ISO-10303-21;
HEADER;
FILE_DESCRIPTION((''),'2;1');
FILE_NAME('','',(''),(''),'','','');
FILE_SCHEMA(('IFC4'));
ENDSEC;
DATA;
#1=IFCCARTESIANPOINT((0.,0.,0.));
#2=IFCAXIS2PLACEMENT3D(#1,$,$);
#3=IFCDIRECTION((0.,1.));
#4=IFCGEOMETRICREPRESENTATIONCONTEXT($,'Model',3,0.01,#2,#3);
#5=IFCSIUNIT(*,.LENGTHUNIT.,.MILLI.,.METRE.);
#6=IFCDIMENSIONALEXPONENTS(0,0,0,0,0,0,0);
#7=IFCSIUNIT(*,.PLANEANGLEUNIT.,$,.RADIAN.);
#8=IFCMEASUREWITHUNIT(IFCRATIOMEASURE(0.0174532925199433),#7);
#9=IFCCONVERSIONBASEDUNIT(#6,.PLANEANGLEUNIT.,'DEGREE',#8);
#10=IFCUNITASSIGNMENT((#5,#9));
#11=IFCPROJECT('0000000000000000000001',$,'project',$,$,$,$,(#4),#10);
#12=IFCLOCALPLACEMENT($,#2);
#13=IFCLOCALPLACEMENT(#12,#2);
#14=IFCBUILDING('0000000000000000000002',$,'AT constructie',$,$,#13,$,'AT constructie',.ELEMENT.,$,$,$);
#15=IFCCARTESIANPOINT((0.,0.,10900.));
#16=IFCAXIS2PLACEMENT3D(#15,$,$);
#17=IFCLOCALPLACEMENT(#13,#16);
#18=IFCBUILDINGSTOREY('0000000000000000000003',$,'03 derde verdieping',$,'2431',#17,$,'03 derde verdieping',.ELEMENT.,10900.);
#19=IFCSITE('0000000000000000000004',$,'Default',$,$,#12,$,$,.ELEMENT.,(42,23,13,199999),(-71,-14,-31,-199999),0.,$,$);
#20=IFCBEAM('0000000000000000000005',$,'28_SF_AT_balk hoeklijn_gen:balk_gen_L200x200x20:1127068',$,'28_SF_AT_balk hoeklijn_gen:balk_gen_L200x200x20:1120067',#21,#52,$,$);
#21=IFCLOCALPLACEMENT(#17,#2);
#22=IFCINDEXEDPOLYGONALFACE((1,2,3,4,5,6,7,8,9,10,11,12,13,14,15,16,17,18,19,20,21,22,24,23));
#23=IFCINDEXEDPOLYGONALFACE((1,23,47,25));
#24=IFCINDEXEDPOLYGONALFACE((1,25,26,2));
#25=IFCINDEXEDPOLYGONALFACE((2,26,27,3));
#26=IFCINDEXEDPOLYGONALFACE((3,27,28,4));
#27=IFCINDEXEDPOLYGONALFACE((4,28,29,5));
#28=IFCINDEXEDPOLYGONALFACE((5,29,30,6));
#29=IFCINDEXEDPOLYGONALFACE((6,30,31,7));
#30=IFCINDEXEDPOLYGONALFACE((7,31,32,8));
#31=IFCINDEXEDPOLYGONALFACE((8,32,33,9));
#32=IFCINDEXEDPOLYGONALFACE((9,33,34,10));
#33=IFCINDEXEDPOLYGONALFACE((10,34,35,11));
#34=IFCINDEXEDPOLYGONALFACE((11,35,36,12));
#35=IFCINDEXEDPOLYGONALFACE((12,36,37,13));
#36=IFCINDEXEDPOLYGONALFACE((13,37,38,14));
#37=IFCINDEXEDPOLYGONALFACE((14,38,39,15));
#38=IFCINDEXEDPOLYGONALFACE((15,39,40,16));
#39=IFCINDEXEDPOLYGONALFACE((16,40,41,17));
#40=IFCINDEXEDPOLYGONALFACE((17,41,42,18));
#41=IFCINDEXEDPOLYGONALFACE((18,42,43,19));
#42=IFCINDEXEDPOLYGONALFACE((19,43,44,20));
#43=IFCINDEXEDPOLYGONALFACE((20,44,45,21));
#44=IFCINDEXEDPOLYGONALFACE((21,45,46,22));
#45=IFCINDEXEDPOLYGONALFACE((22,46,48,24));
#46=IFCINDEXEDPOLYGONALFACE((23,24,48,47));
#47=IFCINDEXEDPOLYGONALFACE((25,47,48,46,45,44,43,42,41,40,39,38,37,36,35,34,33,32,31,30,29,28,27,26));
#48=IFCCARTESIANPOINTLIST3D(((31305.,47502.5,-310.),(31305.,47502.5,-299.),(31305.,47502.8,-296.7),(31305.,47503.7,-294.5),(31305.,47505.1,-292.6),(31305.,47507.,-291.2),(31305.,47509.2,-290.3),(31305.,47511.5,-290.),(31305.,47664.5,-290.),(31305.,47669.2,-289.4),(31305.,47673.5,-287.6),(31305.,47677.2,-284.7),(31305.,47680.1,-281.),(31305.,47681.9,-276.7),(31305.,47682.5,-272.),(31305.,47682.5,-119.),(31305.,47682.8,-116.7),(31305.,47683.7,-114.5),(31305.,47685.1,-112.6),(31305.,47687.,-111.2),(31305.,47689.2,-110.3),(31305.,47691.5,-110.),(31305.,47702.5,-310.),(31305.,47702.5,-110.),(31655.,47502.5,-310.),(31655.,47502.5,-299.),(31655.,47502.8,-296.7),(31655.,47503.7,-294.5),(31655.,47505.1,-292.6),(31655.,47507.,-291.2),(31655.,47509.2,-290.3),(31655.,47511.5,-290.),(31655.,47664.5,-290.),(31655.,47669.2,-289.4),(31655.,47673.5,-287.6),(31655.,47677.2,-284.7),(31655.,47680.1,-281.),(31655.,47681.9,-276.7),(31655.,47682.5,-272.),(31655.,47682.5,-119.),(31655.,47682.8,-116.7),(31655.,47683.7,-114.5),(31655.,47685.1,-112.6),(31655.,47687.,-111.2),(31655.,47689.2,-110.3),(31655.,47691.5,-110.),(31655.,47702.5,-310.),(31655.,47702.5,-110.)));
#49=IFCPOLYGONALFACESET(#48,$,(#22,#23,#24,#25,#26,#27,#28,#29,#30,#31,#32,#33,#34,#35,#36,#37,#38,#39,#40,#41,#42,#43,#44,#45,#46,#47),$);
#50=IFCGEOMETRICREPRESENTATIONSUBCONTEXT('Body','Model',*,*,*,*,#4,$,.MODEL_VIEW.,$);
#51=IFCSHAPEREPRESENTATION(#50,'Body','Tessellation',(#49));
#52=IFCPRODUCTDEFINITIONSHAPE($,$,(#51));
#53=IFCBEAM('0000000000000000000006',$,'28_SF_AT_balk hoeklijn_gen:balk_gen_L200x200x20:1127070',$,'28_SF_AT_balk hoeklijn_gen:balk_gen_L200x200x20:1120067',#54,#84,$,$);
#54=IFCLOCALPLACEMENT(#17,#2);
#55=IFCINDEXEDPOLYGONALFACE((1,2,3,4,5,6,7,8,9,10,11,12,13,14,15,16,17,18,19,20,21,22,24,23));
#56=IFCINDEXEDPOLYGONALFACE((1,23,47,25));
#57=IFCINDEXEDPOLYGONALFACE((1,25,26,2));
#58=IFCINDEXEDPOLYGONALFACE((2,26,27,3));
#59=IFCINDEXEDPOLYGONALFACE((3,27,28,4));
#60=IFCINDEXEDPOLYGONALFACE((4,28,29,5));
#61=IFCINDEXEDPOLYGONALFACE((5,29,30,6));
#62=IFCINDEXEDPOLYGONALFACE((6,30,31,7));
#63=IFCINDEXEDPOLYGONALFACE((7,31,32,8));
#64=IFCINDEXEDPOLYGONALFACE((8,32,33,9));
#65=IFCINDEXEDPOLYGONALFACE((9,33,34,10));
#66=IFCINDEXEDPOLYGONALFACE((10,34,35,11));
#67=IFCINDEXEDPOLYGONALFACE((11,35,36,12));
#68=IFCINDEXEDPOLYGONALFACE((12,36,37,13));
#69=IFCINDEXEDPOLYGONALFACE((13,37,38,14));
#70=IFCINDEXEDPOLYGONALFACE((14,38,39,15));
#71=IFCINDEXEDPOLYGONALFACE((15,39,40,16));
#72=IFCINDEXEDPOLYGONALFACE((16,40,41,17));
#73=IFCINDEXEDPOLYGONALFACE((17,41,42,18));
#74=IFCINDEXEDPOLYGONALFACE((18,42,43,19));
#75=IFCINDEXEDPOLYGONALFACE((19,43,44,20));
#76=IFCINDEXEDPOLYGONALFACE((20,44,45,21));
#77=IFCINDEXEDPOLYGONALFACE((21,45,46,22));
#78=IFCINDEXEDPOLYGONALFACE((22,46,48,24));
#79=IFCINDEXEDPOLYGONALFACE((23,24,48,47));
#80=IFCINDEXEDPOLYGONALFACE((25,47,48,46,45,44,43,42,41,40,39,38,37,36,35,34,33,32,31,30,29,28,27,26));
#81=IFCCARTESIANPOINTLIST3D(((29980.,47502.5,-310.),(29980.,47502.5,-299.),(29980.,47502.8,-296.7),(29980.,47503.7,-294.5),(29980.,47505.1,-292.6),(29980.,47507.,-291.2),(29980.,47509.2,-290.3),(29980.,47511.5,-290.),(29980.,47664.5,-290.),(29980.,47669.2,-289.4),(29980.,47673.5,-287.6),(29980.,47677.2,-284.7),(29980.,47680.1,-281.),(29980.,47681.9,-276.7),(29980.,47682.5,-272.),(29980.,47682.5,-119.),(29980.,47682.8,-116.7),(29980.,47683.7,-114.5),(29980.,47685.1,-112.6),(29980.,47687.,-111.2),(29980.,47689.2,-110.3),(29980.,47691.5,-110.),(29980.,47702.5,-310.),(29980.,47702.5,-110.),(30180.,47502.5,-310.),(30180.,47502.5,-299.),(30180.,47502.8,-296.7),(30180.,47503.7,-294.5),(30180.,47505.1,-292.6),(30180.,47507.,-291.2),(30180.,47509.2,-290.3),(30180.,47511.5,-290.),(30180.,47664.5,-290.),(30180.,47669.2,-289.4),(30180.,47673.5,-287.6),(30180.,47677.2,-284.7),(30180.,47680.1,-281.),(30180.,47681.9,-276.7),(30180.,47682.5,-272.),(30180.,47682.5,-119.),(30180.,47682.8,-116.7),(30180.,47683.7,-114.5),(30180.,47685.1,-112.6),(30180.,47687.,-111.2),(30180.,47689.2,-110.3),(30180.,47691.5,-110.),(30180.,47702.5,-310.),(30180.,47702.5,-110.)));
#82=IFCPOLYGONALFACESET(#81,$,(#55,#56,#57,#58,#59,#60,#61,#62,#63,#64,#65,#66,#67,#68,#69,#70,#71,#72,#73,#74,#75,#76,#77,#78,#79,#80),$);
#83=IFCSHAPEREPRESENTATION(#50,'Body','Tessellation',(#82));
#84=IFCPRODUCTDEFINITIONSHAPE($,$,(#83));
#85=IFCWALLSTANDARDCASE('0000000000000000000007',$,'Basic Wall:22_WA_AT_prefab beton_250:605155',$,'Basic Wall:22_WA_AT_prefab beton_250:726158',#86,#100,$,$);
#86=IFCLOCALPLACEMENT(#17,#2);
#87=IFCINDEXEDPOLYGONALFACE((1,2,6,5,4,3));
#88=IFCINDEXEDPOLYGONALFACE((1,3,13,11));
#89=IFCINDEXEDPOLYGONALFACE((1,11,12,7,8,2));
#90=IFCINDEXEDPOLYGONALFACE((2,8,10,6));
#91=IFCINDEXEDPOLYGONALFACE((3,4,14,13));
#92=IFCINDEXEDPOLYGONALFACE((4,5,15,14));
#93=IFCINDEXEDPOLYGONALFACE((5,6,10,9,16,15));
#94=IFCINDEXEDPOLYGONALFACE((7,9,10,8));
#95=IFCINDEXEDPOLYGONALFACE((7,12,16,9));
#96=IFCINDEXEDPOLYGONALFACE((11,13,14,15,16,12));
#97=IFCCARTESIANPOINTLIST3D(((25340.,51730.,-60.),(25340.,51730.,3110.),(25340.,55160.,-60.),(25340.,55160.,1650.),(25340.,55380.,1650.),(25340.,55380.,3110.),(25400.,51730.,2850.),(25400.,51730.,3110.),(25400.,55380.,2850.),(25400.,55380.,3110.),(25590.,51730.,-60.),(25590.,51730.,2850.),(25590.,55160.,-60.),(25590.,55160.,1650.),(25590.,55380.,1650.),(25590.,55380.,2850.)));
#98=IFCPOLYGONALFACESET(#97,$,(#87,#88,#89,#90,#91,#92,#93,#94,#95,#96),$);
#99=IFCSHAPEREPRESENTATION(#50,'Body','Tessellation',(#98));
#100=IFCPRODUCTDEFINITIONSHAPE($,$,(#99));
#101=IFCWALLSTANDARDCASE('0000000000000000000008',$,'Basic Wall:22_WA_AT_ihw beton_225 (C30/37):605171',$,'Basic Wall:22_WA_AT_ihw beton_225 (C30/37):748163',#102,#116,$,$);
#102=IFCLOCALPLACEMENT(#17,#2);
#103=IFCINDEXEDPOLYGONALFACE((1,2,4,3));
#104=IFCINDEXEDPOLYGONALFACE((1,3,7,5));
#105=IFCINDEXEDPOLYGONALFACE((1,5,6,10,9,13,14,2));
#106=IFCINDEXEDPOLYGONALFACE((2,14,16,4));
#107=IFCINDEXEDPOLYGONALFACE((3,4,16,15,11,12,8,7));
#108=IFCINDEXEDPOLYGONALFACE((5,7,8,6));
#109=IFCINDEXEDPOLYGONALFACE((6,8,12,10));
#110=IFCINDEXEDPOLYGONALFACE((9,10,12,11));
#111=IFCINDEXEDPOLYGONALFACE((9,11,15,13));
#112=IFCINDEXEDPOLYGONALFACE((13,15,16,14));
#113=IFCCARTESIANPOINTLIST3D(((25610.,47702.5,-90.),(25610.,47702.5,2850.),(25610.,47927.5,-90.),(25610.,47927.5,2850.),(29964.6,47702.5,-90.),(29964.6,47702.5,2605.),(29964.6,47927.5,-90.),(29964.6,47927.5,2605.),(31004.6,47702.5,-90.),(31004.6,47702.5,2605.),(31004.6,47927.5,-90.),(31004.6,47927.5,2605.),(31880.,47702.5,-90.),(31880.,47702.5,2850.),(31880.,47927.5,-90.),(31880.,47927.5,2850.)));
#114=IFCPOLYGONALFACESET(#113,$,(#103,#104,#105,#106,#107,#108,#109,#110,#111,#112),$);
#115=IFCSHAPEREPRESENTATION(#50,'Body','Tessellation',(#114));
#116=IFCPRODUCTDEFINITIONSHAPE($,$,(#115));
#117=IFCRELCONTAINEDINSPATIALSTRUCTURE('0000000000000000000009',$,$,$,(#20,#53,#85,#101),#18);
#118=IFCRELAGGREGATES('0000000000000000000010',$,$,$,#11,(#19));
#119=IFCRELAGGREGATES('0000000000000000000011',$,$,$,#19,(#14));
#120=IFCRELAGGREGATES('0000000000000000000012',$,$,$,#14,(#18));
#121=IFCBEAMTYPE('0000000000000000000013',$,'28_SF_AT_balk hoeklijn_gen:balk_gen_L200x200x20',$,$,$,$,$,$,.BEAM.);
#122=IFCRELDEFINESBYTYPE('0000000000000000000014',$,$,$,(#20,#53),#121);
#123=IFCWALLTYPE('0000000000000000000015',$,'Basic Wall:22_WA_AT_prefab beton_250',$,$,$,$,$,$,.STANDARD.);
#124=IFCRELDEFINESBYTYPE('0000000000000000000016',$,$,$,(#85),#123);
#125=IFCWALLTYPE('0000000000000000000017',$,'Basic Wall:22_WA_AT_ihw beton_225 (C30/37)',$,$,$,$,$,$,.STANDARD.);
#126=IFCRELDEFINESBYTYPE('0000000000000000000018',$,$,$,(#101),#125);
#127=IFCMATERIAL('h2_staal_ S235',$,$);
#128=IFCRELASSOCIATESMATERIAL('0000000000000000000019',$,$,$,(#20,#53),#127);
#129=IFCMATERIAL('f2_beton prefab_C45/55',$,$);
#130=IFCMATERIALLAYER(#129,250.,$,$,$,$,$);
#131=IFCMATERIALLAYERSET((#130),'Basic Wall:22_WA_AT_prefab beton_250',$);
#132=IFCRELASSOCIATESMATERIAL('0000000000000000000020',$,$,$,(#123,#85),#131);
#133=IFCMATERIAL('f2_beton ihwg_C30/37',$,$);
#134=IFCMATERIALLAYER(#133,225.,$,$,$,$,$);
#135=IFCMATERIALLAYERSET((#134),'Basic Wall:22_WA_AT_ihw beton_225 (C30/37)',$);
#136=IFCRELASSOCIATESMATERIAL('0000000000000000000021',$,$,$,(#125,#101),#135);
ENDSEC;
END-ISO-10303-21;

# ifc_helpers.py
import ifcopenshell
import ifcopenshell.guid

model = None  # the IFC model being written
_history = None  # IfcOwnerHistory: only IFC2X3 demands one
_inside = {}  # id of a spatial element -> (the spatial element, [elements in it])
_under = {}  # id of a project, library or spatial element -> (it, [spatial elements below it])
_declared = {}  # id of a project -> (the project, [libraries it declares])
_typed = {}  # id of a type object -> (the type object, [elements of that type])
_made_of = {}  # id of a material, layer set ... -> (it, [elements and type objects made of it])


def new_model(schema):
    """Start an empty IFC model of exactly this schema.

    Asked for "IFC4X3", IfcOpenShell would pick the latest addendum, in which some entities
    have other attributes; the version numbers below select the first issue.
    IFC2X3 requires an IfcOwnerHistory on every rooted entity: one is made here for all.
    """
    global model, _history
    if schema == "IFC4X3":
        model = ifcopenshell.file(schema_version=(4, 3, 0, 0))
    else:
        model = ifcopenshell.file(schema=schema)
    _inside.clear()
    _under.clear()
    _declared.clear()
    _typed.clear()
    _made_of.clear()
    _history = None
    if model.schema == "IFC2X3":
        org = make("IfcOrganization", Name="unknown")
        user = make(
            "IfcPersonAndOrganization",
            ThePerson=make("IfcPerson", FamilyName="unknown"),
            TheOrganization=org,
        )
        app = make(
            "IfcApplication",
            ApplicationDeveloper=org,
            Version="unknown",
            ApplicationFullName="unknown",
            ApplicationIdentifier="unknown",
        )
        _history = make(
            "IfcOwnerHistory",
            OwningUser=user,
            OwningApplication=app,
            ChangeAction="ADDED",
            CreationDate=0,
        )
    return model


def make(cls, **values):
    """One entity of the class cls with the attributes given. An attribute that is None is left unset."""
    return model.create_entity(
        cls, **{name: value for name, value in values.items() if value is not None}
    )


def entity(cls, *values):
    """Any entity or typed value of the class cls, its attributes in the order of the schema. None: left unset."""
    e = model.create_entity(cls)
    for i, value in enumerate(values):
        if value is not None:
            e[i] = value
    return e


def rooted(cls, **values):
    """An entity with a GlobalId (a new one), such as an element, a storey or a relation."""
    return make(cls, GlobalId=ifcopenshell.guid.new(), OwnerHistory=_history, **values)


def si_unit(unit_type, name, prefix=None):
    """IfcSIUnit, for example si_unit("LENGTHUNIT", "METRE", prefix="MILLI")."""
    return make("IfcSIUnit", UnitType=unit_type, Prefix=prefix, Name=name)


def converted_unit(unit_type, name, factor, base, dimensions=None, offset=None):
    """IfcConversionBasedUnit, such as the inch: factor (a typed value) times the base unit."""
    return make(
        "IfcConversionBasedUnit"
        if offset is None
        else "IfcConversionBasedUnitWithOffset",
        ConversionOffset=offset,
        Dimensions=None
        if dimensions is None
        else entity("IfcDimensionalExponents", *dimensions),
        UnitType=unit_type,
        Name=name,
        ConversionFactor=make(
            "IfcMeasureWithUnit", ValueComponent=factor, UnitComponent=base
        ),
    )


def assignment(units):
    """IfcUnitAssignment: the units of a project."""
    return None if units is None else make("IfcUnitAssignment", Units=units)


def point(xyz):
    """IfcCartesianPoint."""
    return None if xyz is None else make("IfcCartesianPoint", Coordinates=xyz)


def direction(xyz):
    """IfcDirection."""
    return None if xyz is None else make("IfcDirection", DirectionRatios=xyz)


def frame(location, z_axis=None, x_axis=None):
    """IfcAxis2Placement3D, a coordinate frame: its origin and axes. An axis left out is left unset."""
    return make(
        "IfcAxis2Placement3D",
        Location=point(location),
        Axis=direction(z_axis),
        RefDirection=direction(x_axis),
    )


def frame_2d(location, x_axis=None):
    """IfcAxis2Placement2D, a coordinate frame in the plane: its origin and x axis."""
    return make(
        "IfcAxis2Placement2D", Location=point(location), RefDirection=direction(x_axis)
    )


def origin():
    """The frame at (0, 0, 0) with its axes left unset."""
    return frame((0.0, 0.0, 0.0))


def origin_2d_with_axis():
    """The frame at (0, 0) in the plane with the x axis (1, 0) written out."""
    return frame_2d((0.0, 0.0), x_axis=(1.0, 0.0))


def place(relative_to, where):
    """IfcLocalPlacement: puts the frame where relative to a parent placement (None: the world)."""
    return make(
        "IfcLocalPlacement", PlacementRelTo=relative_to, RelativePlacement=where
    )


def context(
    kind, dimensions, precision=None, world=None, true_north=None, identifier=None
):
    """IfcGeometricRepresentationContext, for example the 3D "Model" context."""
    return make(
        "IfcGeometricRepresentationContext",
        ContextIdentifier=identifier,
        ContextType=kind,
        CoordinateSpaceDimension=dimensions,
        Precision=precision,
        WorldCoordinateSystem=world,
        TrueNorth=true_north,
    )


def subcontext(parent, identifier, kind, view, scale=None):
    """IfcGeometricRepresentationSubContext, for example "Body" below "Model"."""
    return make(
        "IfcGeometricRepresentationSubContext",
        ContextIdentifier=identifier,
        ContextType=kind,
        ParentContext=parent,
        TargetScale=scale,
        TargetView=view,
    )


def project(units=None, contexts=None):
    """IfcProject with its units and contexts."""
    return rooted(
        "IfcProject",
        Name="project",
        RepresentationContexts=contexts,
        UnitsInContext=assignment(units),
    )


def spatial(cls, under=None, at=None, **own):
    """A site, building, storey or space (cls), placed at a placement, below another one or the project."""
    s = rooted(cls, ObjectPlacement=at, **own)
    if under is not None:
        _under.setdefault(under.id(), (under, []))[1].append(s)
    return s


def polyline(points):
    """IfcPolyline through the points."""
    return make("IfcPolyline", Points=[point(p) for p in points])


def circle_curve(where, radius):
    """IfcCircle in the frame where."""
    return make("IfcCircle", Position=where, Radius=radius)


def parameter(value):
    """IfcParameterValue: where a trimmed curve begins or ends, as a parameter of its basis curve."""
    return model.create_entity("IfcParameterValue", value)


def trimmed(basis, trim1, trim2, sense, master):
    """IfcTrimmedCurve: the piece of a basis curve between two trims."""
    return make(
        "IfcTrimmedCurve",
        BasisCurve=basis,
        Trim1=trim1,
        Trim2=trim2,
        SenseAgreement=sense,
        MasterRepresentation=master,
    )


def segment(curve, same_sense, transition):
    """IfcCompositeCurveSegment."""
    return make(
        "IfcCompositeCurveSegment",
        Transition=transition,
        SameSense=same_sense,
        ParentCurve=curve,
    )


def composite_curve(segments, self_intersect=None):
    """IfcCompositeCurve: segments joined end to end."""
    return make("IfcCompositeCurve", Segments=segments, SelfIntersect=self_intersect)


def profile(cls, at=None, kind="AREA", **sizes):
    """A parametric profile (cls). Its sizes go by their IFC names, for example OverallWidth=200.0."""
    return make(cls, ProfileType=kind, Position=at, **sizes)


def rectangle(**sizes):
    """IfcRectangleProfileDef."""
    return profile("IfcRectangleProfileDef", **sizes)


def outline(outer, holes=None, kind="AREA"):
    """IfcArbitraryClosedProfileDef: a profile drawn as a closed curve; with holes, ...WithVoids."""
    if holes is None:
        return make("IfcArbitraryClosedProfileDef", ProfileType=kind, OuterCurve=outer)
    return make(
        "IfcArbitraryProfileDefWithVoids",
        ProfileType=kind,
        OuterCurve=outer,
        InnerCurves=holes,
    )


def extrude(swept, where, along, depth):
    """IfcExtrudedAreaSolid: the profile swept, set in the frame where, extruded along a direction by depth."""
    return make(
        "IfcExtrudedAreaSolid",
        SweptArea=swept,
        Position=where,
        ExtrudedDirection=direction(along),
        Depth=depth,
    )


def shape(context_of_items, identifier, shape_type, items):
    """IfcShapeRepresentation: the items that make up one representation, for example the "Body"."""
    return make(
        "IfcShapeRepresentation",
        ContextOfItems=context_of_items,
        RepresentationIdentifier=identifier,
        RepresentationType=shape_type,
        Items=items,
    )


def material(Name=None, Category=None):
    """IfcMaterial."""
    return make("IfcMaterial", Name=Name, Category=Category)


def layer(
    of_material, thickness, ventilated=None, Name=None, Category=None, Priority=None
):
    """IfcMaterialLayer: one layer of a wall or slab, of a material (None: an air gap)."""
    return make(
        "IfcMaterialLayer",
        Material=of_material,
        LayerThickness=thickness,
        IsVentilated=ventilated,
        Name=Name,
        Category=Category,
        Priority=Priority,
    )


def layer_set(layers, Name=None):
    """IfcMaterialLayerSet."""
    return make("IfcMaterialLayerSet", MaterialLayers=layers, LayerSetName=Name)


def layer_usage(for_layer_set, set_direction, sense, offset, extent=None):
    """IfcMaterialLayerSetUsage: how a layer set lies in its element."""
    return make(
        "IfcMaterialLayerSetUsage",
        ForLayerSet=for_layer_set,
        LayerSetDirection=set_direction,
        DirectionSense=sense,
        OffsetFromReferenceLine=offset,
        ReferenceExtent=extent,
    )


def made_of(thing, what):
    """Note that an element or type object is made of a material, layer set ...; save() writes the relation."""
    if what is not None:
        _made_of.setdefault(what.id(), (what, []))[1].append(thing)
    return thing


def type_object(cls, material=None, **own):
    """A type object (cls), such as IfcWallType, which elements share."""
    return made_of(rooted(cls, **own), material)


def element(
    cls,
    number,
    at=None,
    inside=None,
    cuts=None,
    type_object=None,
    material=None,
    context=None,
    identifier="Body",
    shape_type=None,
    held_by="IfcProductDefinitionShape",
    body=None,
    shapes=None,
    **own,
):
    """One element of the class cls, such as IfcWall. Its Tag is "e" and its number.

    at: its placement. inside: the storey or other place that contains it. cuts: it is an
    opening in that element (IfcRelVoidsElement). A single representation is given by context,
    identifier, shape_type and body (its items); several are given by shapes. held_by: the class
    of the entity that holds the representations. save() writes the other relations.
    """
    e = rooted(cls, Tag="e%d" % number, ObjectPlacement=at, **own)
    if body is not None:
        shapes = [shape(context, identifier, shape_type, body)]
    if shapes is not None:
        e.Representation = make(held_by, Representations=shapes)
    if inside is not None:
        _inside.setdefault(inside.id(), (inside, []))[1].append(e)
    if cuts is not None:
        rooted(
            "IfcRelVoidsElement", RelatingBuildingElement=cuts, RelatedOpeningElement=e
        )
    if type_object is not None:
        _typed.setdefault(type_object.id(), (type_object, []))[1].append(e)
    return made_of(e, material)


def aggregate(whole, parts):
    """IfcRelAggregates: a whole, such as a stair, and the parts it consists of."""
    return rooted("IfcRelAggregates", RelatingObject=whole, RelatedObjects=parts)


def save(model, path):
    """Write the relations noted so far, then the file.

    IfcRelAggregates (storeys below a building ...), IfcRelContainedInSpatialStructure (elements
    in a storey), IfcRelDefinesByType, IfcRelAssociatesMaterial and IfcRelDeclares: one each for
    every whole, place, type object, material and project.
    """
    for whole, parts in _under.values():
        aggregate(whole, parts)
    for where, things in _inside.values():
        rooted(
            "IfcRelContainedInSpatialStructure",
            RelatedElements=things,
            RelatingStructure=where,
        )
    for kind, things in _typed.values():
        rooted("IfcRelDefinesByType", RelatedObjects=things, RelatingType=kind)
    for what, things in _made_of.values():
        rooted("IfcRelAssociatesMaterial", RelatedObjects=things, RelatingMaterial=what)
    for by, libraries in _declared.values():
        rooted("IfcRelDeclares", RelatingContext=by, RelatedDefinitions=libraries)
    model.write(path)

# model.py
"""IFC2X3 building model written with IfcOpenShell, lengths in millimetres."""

from ifc_helpers import new_model, entity, si_unit, converted_unit, direction, frame, frame_2d, origin, origin_2d_with_axis, place, context, subcontext, project, spatial, polyline, circle_curve, parameter, trimmed, segment, composite_curve, rectangle, outline, extrude, material, layer, layer_set, layer_usage, type_object, element, save


model = new_model("IFC2X3")

# Units and contexts
model_context = context("Model", 3, precision=0.01, world=origin(), true_north=direction((0.0, 1.0)))
body_context = subcontext(model_context, "Body", "Model", "MODEL_VIEW")
ifc_project = project(units=[si_unit("LENGTHUNIT", "METRE", prefix="MILLI"), converted_unit("PLANEANGLEUNIT", "DEGREE", entity("IfcRatioMeasure", 0.0174532925199433), si_unit("PLANEANGLEUNIT", "RADIAN"), dimensions=[0, 0, 0, 0, 0, 0, 0])], contexts=[model_context])

# Site, building, storey
site_placement = place(None, origin())
site = spatial("IfcSite", under=ifc_project, at=site_placement, Name="Default", CompositionType="ELEMENT", RefLatitude=(42, 23, 13, 199999), RefLongitude=(-71, -14, -31, -199999), RefElevation=0.0)
building_placement = place(site_placement, origin())
building = spatial("IfcBuilding", under=site, at=building_placement, Name="AT constructie", LongName="AT constructie", CompositionType="ELEMENT")
storey_placement = place(building_placement, frame((0.0, 0.0, 10900.0)))
storey = spatial("IfcBuildingStorey", under=building, at=storey_placement, Name="03 derde verdieping", ObjectType="2431", LongName="03 derde verdieping", CompositionType="ELEMENT", Elevation=10900.0)

# Shared definitions
ifc_material_1 = material(Name="f2_beton prefab_C45/55")

# Beams
ifc_material_2 = material(Name="h2_staal_ S235")
beam_type_1 = type_object("IfcBeamType", Name="28_SF_AT_balk hoeklijn_gen:balk_gen_L200x200x20", PredefinedType="BEAM")
beam_1_placement = place(storey_placement, frame((31655.0, 47702.5, -70.0), z_axis=(0.0, 0.0, 1.0), x_axis=(-1.0, 0.0, 0.0)))
element("IfcBeam", 1, at=beam_1_placement, inside=storey, type_object=beam_type_1, material=ifc_material_2, Name="28_SF_AT_balk hoeklijn_gen:balk_gen_L200x200x20:1127068", ObjectType="28_SF_AT_balk hoeklijn_gen:balk_gen_L200x200x20:1120067", context=body_context, shape_type="SweptSolid", body=[
    extrude(outline(composite_curve([segment(polyline([(-124.4, -75.6), (75.6, -75.6)]), True, "CONTINUOUS"), segment(polyline([(75.6, -75.6), (75.6, 124.4)]), True, "CONTINUOUS"), segment(polyline([(75.6, 124.4), (64.6, 124.4)]), True, "CONTINUOUS"), segment(trimmed(circle_curve(frame_2d((64.6, 115.4), x_axis=(0.0, 1.0)), 9.0), [parameter(0.0)], [parameter(90.0)], True, "PARAMETER"), True, "CONTINUOUS"), segment(polyline([(55.6, 115.4), (55.6, -37.6)]), True, "CONTINUOUS"), segment(trimmed(circle_curve(frame_2d((37.6, -37.6), x_axis=(1.0, 0.0)), 18.0), [parameter(270.0)], [parameter(0.0)], True, "PARAMETER"), False, "CONTINUOUS"), segment(polyline([(37.6, -55.6), (-115.4, -55.6)]), True, "CONTINUOUS"), segment(trimmed(circle_curve(frame_2d((-115.4, -64.6), x_axis=(0.0, 1.0)), 9.0), [parameter(0.0)], [parameter(90.0)], True, "PARAMETER"), True, "CONTINUOUS"), segment(polyline([(-124.4, -64.6), (-124.4, -75.6)]), True, "CONTINUOUS")], self_intersect=False)), frame((0.0, 75.6, -164.4), z_axis=(1.0, 0.0, 0.0), x_axis=(0.0, 0.0, -1.0)), (0.0, 0.0, 1.0), 350.0),
])
beam_2_placement = place(storey_placement, frame((30180.0, 47702.5, -70.0), z_axis=(0.0, 0.0, 1.0), x_axis=(-1.0, 0.0, 0.0)))
element("IfcBeam", 2, at=beam_2_placement, inside=storey, type_object=beam_type_1, material=ifc_material_2, Name="28_SF_AT_balk hoeklijn_gen:balk_gen_L200x200x20:1127070", ObjectType="28_SF_AT_balk hoeklijn_gen:balk_gen_L200x200x20:1120067", context=body_context, shape_type="SweptSolid", body=[
    extrude(outline(composite_curve([segment(polyline([(-124.4, -75.6), (75.6, -75.6)]), True, "CONTINUOUS"), segment(polyline([(75.6, -75.6), (75.6, 124.4)]), True, "CONTINUOUS"), segment(polyline([(75.6, 124.4), (64.6, 124.4)]), True, "CONTINUOUS"), segment(trimmed(circle_curve(frame_2d((64.6, 115.4), x_axis=(0.0, 1.0)), 9.0), [parameter(0.0)], [parameter(90.0)], True, "PARAMETER"), True, "CONTINUOUS"), segment(polyline([(55.6, 115.4), (55.6, -37.6)]), True, "CONTINUOUS"), segment(trimmed(circle_curve(frame_2d((37.6, -37.6), x_axis=(1.0, 0.0)), 18.0), [parameter(270.0)], [parameter(0.0)], True, "PARAMETER"), False, "CONTINUOUS"), segment(polyline([(37.6, -55.6), (-115.4, -55.6)]), True, "CONTINUOUS"), segment(trimmed(circle_curve(frame_2d((-115.4, -64.6), x_axis=(0.0, 1.0)), 9.0), [parameter(0.0)], [parameter(90.0)], True, "PARAMETER"), True, "CONTINUOUS"), segment(polyline([(-124.4, -64.6), (-124.4, -75.6)]), True, "CONTINUOUS")], self_intersect=False)), frame((0.0, 75.6, -164.4), z_axis=(1.0, 0.0, 0.0), x_axis=(0.0, 0.0, -1.0)), (0.0, 0.0, 1.0), 200.0),
])

# Wall, openings
ifc_layer_1 = layer(ifc_material_1, 250.0)
ifc_layer_set_1 = layer_set([ifc_layer_1], Name="Basic Wall:22_WA_AT_prefab beton_250")
ifc_layer_usage_1 = layer_usage(ifc_layer_set_1, "AXIS2", "POSITIVE", -125.0)
wall_type_1 = type_object("IfcWallType", Name="Basic Wall:22_WA_AT_prefab beton_250", PredefinedType="STANDARD", material=ifc_layer_set_1)
wall_1_placement = place(storey_placement, frame((25465.0, 55380.0, -60.0), z_axis=(0.0, 0.0, 1.0), x_axis=(0.0, -1.0, 0.0)))
wall_1 = element("IfcWallStandardCase", 3, at=wall_1_placement, inside=storey, type_object=wall_type_1, material=ifc_layer_usage_1, Name="Basic Wall:22_WA_AT_prefab beton_250:605155", ObjectType="Basic Wall:22_WA_AT_prefab beton_250:726158", context=body_context, shape_type="SweptSolid", body=[
    extrude(rectangle(XDim=3650.0, YDim=250.0, at=frame_2d((1825.0, 0.0), x_axis=(-1.0, 0.0))), origin(), (0.0, 0.0, 1.0), 3170.0),
])
opening_1_placement = place(wall_1_placement, origin())
element("IfcOpeningElement", 4, at=opening_1_placement, cuts=wall_1, ObjectType="Recess", context=body_context, shape_type="SweptSolid", body=[
    extrude(rectangle(XDim=260.0, YDim=3900.0, at=frame_2d((0.0, 0.0), x_axis=(0.0, 1.0))), frame((1950.0, -65.0, 3040.0), z_axis=(0.0, 1.0, 0.0), x_axis=(1.0, 0.0, 0.0)), (0.0, 0.0, 1.0), 190.0),
])
opening_2_placement = place(wall_1_placement, origin())
element("IfcOpeningElement", 5, at=opening_2_placement, cuts=wall_1, ObjectType="Opening", context=body_context, shape_type="SweptSolid", body=[
    extrude(rectangle(XDim=1710.0, YDim=220.0, at=origin_2d_with_axis()), frame((110.0, 125.0, 855.0), z_axis=(0.0, -1.0, 0.0), x_axis=(0.0, 0.0, -1.0)), (0.0, 0.0, 1.0), 250.0),
])

# Wall, opening
ifc_material_3 = material(Name="f2_beton ihwg_C30/37")
ifc_layer_2 = layer(ifc_material_3, 225.0)
ifc_layer_set_2 = layer_set([ifc_layer_2], Name="Basic Wall:22_WA_AT_ihw beton_225 (C30/37)")
ifc_layer_usage_2 = layer_usage(ifc_layer_set_2, "AXIS2", "POSITIVE", -112.5)
wall_type_2 = type_object("IfcWallType", Name="Basic Wall:22_WA_AT_ihw beton_225 (C30/37)", PredefinedType="STANDARD", material=ifc_layer_set_2)
wall_2_placement = place(storey_placement, frame((25610.0, 47815.0, -90.0)))
wall_2 = element("IfcWallStandardCase", 6, at=wall_2_placement, inside=storey, type_object=wall_type_2, material=ifc_layer_usage_2, Name="Basic Wall:22_WA_AT_ihw beton_225 (C30/37):605171", ObjectType="Basic Wall:22_WA_AT_ihw beton_225 (C30/37):748163", context=body_context, shape_type="SweptSolid", body=[
    extrude(rectangle(XDim=6270.0, YDim=225.0, at=frame_2d((3135.0, 0.0), x_axis=(-1.0, 0.0))), origin(), (0.0, 0.0, 1.0), 2940.0),
])
opening_3_placement = place(wall_2_placement, origin())
element("IfcOpeningElement", 7, at=opening_3_placement, cuts=wall_2, ObjectType="Opening", context=body_context, shape_type="SweptSolid", body=[
    extrude(rectangle(XDim=2695.0, YDim=1040.0, at=frame_2d((0.0, 0.0), x_axis=(1.0, 0.0))), frame((4874.6, -1411.5, 1347.5), z_axis=(0.0, 1.0, 0.0), x_axis=(0.0, 0.0, -1.0)), (0.0, 0.0, 1.0), 3048.0),
])

save(model, "model.ifc")
